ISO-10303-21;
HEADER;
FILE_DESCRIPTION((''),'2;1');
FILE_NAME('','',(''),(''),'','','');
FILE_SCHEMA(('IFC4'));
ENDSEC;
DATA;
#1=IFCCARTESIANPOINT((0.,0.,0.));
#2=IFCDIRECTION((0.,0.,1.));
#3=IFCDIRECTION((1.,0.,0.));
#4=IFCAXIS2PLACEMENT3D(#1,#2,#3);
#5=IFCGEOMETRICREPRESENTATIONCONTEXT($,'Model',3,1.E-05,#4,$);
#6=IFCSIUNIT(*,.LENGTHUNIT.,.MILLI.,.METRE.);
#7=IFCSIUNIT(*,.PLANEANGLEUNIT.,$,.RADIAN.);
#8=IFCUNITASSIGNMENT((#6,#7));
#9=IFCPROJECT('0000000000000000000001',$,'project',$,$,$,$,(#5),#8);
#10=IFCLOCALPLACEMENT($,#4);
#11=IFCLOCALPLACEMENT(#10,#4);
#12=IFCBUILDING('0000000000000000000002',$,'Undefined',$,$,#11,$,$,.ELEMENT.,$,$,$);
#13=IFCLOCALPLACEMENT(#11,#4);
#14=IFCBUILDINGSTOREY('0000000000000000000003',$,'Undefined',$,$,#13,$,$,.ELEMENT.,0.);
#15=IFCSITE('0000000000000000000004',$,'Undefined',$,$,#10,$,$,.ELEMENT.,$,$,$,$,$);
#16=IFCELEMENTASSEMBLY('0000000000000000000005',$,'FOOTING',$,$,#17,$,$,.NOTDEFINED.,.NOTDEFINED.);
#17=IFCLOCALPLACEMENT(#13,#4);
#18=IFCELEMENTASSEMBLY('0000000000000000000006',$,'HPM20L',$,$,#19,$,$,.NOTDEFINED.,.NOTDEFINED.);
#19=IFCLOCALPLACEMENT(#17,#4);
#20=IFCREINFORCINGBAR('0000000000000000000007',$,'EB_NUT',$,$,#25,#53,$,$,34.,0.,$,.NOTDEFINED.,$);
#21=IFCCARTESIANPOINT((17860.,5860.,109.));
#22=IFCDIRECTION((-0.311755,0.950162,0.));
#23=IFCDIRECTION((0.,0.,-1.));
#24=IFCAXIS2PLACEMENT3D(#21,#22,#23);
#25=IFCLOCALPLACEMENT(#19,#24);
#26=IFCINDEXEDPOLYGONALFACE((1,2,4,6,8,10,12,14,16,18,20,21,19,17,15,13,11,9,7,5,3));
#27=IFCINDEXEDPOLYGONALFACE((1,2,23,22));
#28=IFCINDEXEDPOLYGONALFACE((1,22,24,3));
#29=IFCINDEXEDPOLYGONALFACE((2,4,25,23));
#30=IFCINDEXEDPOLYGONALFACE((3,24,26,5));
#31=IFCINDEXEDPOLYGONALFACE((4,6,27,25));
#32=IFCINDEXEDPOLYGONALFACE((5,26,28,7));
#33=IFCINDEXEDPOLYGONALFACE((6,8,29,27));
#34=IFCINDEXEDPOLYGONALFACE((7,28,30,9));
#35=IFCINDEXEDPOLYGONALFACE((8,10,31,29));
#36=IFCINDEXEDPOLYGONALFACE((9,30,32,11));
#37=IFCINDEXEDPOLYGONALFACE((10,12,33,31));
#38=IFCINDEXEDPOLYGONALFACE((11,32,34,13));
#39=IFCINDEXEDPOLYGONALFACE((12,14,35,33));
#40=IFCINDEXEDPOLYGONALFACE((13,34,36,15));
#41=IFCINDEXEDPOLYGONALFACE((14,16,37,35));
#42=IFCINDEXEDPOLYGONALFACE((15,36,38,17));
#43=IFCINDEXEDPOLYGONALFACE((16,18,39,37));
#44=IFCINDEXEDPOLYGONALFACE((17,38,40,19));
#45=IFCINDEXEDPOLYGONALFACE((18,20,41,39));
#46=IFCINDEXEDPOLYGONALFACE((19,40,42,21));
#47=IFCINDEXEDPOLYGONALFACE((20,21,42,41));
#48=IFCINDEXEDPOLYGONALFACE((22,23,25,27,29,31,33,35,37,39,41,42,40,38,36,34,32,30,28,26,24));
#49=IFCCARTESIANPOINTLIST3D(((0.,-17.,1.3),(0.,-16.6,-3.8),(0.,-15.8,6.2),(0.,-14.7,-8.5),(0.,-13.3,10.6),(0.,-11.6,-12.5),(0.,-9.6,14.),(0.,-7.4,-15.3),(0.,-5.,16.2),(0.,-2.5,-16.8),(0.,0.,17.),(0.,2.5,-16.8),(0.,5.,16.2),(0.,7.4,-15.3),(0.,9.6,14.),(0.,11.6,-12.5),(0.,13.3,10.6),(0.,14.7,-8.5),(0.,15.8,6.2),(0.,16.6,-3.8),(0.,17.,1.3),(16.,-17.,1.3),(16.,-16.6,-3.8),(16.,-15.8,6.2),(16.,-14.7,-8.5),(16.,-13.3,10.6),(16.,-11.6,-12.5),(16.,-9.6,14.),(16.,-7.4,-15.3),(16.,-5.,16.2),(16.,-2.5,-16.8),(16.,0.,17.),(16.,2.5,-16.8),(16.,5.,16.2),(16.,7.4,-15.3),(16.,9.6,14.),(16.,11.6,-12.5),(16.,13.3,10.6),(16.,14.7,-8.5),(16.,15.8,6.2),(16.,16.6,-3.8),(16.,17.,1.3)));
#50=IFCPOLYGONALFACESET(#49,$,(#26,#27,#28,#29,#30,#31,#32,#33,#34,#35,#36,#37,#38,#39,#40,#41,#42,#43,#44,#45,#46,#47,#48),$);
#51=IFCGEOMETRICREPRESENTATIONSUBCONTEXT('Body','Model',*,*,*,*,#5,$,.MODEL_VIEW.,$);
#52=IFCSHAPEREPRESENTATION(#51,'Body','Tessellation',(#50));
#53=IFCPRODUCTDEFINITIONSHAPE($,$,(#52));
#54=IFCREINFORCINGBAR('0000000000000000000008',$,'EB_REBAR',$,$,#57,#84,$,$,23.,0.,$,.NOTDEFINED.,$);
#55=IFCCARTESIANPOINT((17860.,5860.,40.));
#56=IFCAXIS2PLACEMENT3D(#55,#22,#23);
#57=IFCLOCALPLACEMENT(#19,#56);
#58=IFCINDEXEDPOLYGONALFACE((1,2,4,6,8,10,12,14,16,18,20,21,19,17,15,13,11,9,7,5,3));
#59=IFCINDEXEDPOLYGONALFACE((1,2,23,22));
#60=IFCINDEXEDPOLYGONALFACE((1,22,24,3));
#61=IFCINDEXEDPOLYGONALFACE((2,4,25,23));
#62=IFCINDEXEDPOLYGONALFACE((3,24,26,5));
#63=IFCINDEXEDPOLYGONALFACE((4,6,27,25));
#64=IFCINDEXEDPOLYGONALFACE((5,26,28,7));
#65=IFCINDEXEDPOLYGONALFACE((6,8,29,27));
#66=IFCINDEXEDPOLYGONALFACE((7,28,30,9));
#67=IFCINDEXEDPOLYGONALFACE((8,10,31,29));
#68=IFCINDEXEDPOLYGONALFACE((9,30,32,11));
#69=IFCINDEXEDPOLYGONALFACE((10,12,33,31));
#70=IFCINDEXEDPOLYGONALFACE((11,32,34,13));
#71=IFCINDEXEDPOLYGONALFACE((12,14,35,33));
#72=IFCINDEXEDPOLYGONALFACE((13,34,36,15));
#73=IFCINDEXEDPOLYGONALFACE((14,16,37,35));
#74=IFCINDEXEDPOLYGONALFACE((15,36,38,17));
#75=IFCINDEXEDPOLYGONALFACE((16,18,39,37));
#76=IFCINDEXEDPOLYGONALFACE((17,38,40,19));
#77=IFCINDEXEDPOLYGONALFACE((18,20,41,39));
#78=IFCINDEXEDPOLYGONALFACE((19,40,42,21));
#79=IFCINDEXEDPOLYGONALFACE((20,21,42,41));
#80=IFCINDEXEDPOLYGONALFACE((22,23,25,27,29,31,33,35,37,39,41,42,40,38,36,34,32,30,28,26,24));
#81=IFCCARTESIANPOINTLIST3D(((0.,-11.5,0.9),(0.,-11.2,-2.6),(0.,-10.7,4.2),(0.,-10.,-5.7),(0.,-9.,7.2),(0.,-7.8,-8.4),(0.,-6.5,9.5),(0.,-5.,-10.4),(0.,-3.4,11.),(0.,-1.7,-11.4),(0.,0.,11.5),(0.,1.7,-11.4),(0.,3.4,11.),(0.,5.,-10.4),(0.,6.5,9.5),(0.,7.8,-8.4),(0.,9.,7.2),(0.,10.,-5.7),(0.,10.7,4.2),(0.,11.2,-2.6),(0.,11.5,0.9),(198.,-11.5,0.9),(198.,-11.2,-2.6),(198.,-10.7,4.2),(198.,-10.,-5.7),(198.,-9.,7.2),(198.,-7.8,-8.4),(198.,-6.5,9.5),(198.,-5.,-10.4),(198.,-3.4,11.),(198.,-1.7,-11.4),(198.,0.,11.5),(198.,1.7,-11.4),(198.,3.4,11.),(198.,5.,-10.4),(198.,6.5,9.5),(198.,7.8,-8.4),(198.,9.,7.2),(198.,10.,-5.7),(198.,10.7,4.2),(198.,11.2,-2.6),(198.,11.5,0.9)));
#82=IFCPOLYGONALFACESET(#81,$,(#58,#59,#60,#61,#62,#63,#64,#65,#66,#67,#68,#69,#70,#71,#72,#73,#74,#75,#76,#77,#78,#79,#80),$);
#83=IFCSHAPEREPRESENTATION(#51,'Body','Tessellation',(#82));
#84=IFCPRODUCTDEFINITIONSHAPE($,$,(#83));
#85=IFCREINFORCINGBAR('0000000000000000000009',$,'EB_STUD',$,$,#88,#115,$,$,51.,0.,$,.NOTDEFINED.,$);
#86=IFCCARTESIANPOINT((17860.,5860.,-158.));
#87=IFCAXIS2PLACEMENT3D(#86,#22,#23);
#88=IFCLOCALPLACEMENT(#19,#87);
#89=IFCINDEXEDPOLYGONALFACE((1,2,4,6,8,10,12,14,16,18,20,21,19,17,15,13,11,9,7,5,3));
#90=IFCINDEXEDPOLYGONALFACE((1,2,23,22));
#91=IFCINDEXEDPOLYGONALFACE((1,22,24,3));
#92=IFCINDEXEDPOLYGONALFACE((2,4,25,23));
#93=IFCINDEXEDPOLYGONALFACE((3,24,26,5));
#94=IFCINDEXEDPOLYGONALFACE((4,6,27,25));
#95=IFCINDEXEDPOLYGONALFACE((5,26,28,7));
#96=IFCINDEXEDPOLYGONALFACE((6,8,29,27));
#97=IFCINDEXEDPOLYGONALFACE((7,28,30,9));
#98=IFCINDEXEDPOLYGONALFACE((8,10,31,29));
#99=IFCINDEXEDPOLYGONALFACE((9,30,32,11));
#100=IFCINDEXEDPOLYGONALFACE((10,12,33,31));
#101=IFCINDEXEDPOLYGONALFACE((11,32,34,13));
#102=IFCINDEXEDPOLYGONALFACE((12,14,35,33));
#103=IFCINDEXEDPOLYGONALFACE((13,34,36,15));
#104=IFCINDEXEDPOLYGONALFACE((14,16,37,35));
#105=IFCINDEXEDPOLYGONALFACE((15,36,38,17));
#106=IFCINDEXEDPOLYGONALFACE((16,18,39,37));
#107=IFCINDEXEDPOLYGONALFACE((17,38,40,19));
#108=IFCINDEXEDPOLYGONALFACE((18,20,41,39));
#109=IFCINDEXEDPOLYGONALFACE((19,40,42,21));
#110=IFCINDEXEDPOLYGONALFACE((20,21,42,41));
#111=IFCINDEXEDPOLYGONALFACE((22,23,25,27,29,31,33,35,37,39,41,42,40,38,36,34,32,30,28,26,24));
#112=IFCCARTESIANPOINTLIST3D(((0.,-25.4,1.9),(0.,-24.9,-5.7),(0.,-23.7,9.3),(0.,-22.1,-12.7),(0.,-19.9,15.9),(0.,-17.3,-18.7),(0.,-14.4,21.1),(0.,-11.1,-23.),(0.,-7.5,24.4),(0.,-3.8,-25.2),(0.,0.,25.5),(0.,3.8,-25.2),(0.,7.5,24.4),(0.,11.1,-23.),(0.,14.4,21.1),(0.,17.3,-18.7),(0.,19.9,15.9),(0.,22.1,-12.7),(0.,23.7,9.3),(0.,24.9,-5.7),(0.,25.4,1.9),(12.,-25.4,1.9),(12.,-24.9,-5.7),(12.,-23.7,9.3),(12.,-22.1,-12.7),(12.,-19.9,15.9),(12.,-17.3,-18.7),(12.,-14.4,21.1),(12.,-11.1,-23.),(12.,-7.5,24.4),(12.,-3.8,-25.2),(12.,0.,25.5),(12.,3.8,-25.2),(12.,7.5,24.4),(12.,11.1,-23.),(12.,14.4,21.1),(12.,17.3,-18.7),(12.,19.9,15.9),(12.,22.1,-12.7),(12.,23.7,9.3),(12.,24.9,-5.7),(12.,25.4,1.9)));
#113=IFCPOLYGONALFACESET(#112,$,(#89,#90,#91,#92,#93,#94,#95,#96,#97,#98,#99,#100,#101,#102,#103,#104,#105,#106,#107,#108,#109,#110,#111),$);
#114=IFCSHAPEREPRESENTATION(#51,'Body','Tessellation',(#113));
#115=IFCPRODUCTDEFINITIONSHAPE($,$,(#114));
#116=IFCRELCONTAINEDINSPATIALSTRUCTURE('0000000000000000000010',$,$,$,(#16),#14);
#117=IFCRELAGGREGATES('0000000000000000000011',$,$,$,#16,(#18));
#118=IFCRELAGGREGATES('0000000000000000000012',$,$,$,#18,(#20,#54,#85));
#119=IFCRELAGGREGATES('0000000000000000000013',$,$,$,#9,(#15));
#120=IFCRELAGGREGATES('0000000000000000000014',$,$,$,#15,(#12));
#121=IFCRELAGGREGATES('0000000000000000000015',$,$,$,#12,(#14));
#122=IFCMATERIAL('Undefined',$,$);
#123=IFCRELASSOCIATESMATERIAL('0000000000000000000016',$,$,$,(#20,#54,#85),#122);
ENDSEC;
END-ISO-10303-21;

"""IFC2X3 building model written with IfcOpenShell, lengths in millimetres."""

from ifc_helpers import new_model, entity, si_unit, frame, origin_with_axes, place, context, subcontext, project, spatial, source, transform, mapped, material, element, aggregate, save


model = new_model("IFC2X3")

# Units and contexts
model_context = context("Model", 3, precision=1e-05, world=origin_with_axes())
body_context = subcontext(model_context, "Body", "Model", "MODEL_VIEW")
ifc_project = project(units=[si_unit("LENGTHUNIT", "METRE", prefix="MILLI"), si_unit("PLANEANGLEUNIT", "RADIAN")], contexts=[model_context])

# Site, building, storey
site_placement = place(None, origin_with_axes())
site = spatial("IfcSite", under=ifc_project, at=site_placement, Name="Undefined", CompositionType="ELEMENT")
building_placement = place(site_placement, origin_with_axes())
building = spatial("IfcBuilding", under=site, at=building_placement, Name="Undefined", CompositionType="ELEMENT")
storey_placement = place(building_placement, origin_with_axes())
storey = spatial("IfcBuildingStorey", under=building, at=storey_placement, Name="Undefined", CompositionType="ELEMENT", Elevation=0.0)

# Shared definitions
ifc_material_1 = material(Name="Undefined")

# Element assemblies, reinforcing bars
assembly_1_placement = place(storey_placement, origin_with_axes())
assembly_1 = element("IfcElementAssembly", 1, at=assembly_1_placement, inside=storey, Name="FOOTING", AssemblyPlace="NOTDEFINED", PredefinedType="NOTDEFINED")
assembly_2_placement = place(assembly_1_placement, origin_with_axes())
assembly_2 = element("IfcElementAssembly", 2, at=assembly_2_placement, Name="HPM20L", AssemblyPlace="NOTDEFINED", PredefinedType="NOTDEFINED")
aggregate(assembly_1, [assembly_2])
shared_shape_1 = source(origin_with_axes(), body_context, "Body", "AdvancedSweptSolid", [
    entity("IfcSweptDiskSolid", entity("IfcTrimmedCurve", entity("IfcLine", entity("IfcCartesianPoint", [0.0, 0.0, 0.0]), entity("IfcVector", entity("IfcDirection", [1.0, 0.0, 0.0]), 1.0)), [entity("IfcParameterValue", 0.0)], [entity("IfcParameterValue", 16.0)], True, "PARAMETER"), 17.0, None, 0.0, 16.0),
])
reinforcing_bar_1_placement = place(assembly_2_placement, frame((17860.0, 5860.0, 109.0), z_axis=(-0.311755, 0.950162, 0.0), x_axis=(0.0, 0.0, -1.0)))
reinforcing_bar_1 = element("IfcReinforcingBar", 3, at=reinforcing_bar_1_placement, material=ifc_material_1, Name="EB_NUT", BarRole="NOTDEFINED", CrossSectionArea=0.0, NominalDiameter=34.0, context=body_context, shape_type="MappedRepresentation", body=[
    mapped(shared_shape_1, transform((0.0, 0.0, 0.0))),
])
shared_shape_2 = source(origin_with_axes(), body_context, "Body", "AdvancedSweptSolid", [
    entity("IfcSweptDiskSolid", entity("IfcTrimmedCurve", entity("IfcLine", entity("IfcCartesianPoint", [0.0, 0.0, 0.0]), entity("IfcVector", entity("IfcDirection", [1.0, 0.0, 0.0]), 1.0)), [entity("IfcParameterValue", 0.0)], [entity("IfcParameterValue", 198.0)], True, "PARAMETER"), 11.5, None, 0.0, 198.0),
])
reinforcing_bar_2_placement = place(assembly_2_placement, frame((17860.0, 5860.0, 40.0), z_axis=(-0.311755, 0.950162, 0.0), x_axis=(0.0, 0.0, -1.0)))
reinforcing_bar_2 = element("IfcReinforcingBar", 4, at=reinforcing_bar_2_placement, material=ifc_material_1, Name="EB_REBAR", BarRole="NOTDEFINED", CrossSectionArea=0.0, NominalDiameter=23.0, context=body_context, shape_type="MappedRepresentation", body=[
    mapped(shared_shape_2, transform((0.0, 0.0, 0.0))),
])
shared_shape_3 = source(origin_with_axes(), body_context, "Body", "AdvancedSweptSolid", [
    entity("IfcSweptDiskSolid", entity("IfcTrimmedCurve", entity("IfcLine", entity("IfcCartesianPoint", [0.0, 0.0, 0.0]), entity("IfcVector", entity("IfcDirection", [1.0, 0.0, 0.0]), 1.0)), [entity("IfcParameterValue", 0.0)], [entity("IfcParameterValue", 12.0)], True, "PARAMETER"), 25.5, None, 0.0, 12.0),
])
reinforcing_bar_3_placement = place(assembly_2_placement, frame((17860.0, 5860.0, -158.0), z_axis=(-0.311755, 0.950162, 0.0), x_axis=(0.0, 0.0, -1.0)))
reinforcing_bar_3 = element("IfcReinforcingBar", 5, at=reinforcing_bar_3_placement, material=ifc_material_1, Name="EB_STUD", BarRole="NOTDEFINED", CrossSectionArea=0.0, NominalDiameter=51.0, context=body_context, shape_type="MappedRepresentation", body=[
    mapped(shared_shape_3, transform((0.0, 0.0, 0.0))),
])
aggregate(assembly_2, [reinforcing_bar_1, reinforcing_bar_2, reinforcing_bar_3])

save(model, "model.ifc")
